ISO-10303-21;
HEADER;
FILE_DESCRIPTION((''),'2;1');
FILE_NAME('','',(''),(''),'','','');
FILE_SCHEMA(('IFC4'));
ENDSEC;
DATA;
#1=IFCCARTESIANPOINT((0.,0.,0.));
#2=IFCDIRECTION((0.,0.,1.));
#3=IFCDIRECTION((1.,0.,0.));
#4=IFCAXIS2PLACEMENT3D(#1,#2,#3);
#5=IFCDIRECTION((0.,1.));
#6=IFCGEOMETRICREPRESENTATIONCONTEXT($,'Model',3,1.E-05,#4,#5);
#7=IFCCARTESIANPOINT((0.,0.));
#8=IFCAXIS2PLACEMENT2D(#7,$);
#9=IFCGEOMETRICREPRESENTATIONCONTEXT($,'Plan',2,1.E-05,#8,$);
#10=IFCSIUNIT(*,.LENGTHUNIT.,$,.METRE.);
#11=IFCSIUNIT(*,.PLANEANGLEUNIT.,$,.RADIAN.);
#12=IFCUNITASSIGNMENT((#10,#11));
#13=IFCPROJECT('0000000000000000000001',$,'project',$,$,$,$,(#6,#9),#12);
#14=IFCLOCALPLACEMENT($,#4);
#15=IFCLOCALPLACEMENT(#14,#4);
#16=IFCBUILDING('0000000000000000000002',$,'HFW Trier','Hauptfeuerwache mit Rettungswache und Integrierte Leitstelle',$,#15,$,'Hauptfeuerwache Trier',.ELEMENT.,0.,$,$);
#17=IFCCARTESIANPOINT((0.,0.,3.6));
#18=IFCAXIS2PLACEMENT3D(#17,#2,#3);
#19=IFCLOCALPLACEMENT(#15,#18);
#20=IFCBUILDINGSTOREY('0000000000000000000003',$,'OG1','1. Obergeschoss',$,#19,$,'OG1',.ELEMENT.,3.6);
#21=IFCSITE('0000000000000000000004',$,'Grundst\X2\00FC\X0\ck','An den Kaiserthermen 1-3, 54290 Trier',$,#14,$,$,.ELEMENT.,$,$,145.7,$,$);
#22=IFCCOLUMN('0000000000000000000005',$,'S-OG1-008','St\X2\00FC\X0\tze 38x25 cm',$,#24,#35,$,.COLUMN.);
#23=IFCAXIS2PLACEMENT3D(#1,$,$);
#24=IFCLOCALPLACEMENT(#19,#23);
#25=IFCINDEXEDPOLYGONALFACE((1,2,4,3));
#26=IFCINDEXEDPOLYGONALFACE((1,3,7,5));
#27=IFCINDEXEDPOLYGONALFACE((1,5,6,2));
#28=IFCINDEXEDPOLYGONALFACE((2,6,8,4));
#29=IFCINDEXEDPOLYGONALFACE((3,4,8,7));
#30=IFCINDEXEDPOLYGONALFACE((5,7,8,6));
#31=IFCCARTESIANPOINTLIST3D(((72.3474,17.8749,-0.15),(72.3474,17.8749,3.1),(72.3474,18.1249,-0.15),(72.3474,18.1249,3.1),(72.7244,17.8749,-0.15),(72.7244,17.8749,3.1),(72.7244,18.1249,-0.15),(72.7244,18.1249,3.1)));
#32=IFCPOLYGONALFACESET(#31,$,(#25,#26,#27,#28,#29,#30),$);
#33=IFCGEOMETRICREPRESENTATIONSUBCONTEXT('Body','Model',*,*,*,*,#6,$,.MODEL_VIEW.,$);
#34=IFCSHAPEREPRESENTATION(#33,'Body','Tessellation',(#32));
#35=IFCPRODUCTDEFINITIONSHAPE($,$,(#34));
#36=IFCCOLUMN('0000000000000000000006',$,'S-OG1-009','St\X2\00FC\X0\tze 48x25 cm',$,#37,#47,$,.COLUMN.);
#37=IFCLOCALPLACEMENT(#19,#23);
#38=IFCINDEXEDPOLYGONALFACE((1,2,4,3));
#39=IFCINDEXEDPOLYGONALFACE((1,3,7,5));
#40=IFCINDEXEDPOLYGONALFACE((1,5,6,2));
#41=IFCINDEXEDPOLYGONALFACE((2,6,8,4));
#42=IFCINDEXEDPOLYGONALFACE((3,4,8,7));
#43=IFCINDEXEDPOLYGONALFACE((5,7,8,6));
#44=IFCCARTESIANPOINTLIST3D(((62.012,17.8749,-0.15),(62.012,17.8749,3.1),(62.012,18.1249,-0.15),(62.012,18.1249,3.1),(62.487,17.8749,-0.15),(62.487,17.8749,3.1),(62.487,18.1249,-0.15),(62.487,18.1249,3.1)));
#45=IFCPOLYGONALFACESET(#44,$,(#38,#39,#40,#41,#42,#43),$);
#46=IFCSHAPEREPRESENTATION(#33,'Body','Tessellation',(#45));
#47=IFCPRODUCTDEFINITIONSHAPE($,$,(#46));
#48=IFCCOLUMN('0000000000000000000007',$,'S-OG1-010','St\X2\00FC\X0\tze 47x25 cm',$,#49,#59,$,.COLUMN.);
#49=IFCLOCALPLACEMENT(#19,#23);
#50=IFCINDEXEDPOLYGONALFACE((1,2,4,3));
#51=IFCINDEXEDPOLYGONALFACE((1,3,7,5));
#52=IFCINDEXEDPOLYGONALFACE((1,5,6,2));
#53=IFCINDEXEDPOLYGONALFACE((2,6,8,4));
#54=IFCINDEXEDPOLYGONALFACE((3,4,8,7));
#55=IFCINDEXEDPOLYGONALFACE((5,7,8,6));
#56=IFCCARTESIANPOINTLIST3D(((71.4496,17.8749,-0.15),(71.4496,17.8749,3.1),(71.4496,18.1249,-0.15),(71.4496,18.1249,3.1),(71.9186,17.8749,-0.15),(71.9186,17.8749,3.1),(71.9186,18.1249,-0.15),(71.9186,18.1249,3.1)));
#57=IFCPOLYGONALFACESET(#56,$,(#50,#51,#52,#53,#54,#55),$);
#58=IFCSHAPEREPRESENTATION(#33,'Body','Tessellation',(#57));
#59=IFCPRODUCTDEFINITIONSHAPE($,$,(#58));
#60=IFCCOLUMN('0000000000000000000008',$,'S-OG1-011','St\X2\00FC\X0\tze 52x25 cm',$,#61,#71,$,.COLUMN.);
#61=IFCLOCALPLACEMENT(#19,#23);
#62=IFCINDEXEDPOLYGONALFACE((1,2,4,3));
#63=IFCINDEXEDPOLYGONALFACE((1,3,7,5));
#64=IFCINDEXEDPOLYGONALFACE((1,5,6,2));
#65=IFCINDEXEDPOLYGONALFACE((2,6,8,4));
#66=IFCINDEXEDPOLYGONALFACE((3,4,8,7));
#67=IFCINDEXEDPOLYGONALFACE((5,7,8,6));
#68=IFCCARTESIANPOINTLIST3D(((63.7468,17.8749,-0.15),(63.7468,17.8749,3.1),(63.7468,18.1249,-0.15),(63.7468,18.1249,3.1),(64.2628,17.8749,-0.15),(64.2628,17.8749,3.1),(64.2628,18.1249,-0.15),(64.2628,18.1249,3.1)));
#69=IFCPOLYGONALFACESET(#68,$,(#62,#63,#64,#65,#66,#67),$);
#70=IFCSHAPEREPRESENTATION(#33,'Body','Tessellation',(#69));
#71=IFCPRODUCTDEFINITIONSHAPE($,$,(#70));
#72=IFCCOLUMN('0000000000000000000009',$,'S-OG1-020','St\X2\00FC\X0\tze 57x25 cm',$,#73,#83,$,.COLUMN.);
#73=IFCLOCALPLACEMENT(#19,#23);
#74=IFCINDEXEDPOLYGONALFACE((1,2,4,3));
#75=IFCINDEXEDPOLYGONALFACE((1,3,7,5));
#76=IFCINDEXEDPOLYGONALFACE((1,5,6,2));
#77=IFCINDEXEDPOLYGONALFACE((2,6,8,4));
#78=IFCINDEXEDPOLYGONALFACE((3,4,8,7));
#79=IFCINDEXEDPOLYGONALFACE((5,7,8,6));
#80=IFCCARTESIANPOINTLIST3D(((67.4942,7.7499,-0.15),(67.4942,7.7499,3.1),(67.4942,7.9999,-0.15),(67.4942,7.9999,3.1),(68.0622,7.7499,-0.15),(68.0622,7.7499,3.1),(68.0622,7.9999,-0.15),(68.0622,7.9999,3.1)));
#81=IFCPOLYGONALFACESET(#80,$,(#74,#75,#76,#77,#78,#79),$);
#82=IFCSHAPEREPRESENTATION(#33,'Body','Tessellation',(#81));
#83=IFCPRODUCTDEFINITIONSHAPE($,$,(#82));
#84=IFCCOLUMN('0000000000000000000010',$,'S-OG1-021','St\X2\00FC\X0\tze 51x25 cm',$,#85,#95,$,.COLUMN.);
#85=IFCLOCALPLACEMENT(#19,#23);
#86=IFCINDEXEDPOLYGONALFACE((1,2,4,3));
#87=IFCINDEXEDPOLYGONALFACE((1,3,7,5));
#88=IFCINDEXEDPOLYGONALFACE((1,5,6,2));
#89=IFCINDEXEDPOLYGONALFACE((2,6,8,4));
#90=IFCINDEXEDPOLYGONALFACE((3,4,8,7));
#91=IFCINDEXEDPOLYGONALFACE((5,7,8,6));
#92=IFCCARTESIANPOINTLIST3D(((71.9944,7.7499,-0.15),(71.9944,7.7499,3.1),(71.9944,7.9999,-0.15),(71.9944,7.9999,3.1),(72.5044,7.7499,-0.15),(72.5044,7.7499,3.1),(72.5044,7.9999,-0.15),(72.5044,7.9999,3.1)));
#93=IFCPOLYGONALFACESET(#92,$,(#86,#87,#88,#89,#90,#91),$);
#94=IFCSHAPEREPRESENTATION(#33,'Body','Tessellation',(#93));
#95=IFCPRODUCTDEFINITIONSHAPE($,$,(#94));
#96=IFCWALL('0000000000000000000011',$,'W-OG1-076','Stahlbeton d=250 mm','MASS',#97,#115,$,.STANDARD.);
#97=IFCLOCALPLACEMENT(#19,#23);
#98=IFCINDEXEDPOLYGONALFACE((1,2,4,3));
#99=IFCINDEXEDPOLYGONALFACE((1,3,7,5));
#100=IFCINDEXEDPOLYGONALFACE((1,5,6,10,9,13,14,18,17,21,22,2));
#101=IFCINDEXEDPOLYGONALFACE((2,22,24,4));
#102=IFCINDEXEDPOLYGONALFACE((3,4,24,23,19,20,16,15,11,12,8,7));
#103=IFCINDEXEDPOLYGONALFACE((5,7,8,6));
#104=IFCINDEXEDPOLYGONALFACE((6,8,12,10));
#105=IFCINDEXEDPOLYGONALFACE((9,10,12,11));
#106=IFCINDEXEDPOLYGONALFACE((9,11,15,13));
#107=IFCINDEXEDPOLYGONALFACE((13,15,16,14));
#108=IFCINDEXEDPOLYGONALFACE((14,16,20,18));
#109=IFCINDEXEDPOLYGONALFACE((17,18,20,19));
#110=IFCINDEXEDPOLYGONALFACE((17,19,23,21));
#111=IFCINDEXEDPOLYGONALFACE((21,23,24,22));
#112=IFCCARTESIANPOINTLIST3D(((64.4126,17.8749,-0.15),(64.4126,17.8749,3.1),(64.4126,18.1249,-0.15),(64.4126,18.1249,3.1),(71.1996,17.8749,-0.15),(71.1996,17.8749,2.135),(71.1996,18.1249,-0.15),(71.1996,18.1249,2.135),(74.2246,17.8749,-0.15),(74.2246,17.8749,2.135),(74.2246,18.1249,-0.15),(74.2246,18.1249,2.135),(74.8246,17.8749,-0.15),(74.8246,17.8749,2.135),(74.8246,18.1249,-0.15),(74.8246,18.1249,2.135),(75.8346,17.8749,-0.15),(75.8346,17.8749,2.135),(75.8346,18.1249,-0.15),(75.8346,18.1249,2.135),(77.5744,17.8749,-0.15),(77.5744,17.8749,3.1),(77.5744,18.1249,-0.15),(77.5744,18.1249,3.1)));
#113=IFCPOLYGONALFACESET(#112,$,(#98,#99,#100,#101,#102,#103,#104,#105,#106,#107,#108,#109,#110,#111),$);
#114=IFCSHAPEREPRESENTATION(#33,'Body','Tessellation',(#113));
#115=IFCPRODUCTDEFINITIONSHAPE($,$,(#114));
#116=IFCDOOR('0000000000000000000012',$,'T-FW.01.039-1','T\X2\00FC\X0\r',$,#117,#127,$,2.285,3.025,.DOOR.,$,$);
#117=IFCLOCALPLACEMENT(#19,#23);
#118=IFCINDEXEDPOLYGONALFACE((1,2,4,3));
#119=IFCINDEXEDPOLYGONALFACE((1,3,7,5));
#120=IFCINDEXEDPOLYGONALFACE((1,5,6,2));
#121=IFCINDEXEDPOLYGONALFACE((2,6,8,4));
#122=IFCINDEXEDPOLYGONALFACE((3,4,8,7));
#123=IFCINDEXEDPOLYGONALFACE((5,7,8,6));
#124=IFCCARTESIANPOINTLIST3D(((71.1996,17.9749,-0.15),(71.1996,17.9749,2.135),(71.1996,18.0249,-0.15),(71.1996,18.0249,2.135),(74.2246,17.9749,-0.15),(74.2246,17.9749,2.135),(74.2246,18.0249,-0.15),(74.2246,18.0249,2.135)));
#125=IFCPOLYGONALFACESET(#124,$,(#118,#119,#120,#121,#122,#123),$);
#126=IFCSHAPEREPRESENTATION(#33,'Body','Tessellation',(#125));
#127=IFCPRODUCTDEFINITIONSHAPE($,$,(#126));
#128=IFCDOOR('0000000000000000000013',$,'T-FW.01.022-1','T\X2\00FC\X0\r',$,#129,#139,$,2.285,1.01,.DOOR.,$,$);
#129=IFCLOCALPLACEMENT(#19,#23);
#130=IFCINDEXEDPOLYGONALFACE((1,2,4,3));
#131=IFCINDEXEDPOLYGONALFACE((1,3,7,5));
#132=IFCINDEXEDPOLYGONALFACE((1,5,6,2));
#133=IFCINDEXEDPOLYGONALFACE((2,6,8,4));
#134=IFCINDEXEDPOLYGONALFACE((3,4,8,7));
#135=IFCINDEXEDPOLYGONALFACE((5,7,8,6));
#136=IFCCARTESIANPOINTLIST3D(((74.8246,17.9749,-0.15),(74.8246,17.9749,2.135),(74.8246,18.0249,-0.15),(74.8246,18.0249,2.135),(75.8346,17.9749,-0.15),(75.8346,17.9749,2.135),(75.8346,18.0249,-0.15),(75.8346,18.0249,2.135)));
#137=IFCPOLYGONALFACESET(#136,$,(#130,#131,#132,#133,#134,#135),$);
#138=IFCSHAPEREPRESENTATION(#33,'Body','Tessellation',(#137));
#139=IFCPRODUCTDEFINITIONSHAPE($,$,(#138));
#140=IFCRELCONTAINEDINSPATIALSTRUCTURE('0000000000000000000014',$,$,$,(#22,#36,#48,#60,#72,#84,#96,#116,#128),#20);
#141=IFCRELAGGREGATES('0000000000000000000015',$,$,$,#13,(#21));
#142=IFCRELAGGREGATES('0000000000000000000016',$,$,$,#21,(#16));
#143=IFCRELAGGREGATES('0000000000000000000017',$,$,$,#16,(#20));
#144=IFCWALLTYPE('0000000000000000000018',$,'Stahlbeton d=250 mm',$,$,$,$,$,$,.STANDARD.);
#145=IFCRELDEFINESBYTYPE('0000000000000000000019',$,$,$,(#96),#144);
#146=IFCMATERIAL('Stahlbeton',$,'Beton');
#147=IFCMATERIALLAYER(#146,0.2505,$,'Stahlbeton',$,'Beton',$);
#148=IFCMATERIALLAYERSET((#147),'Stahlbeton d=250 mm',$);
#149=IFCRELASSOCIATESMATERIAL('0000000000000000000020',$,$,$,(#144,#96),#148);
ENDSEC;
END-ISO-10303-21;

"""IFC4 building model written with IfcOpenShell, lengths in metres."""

from ifc_helpers import new_model, si_unit, direction, frame, frame_2d, origin_with_axes, origin_2d, place, context, subcontext, project, spatial, rectangle, extrude, material, layer, layer_set, layer_usage, type_object, element, fill, save


model = new_model("IFC4")

# Units and contexts
model_context = context("Model", 3, precision=1e-05, world=origin_with_axes(), true_north=direction((0.0, 1.0)))
plan_context = context("Plan", 2, precision=1e-05, world=origin_2d())
body_context = subcontext(model_context, "Body", "Model", "MODEL_VIEW")
ifc_project = project(units=[si_unit("LENGTHUNIT", "METRE"), si_unit("PLANEANGLEUNIT", "RADIAN")], contexts=[model_context, plan_context])

# Site, building, storey
site_placement = place(None, origin_with_axes())
site = spatial("IfcSite", under=ifc_project, at=site_placement, Name="Grundstück", Description="An den Kaiserthermen 1-3, 54290 Trier", CompositionType="ELEMENT", RefElevation=145.7)
building_placement = place(site_placement, origin_with_axes())
building = spatial("IfcBuilding", under=site, at=building_placement, Name="HFW Trier", Description="Hauptfeuerwache mit Rettungswache und Integrierte Leitstelle", LongName="Hauptfeuerwache Trier", CompositionType="ELEMENT", ElevationOfRefHeight=0.0)
storey_placement = place(building_placement, frame((0.0, 0.0, 3.6), z_axis=(0.0, 0.0, 1.0), x_axis=(1.0, 0.0, 0.0)))
storey = spatial("IfcBuildingStorey", under=building, at=storey_placement, Name="OG1", Description="1. Obergeschoss", LongName="OG1", CompositionType="ELEMENT", Elevation=3.6)

# Columns
column_1_placement = place(storey_placement, frame((72.3474, 17.9999, -0.15), z_axis=(0.0, 0.0, 1.0), x_axis=(1.0, 0.0, 0.0)))
element("IfcColumn", 1, at=column_1_placement, inside=storey, Name="S-OG1-008", Description="Stütze 38x25 cm", PredefinedType="COLUMN", context=body_context, shape_type="SweptSolid", body=[
    extrude(rectangle(XDim=0.377, YDim=0.25, at=frame_2d((0.1885, 0.0))), origin_with_axes(), (0.0, 0.0, 1.0), 3.25),
])
column_2_placement = place(storey_placement, frame((62.012, 17.9999, -0.15), z_axis=(0.0, 0.0, 1.0), x_axis=(1.0, 0.0, 0.0)))
element("IfcColumn", 2, at=column_2_placement, inside=storey, Name="S-OG1-009", Description="Stütze 48x25 cm", PredefinedType="COLUMN", context=body_context, shape_type="SweptSolid", body=[
    extrude(rectangle(XDim=0.475, YDim=0.25, at=frame_2d((0.2375, 0.0))), origin_with_axes(), (0.0, 0.0, 1.0), 3.25),
])
column_3_placement = place(storey_placement, frame((71.4496, 17.9999, -0.15), z_axis=(0.0, 0.0, 1.0), x_axis=(1.0, 0.0, 0.0)))
element("IfcColumn", 3, at=column_3_placement, inside=storey, Name="S-OG1-010", Description="Stütze 47x25 cm", PredefinedType="COLUMN", context=body_context, shape_type="SweptSolid", body=[
    extrude(rectangle(XDim=0.469, YDim=0.25, at=frame_2d((0.2345, 0.0))), origin_with_axes(), (0.0, 0.0, 1.0), 3.25),
])
column_4_placement = place(storey_placement, frame((63.7468, 17.9999, -0.15), z_axis=(0.0, 0.0, 1.0), x_axis=(1.0, 0.0, 0.0)))
element("IfcColumn", 4, at=column_4_placement, inside=storey, Name="S-OG1-011", Description="Stütze 52x25 cm", PredefinedType="COLUMN", context=body_context, shape_type="SweptSolid", body=[
    extrude(rectangle(XDim=0.516, YDim=0.25, at=frame_2d((0.258, 0.0))), origin_with_axes(), (0.0, 0.0, 1.0), 3.25),
])
column_5_placement = place(storey_placement, frame((67.4942, 7.8749, -0.15), z_axis=(0.0, 0.0, 1.0), x_axis=(1.0, 0.0, 0.0)))
element("IfcColumn", 5, at=column_5_placement, inside=storey, Name="S-OG1-020", Description="Stütze 57x25 cm", PredefinedType="COLUMN", context=body_context, shape_type="SweptSolid", body=[
    extrude(rectangle(XDim=0.568, YDim=0.25, at=frame_2d((0.284, 0.0))), origin_with_axes(), (0.0, 0.0, 1.0), 3.25),
])
column_6_placement = place(storey_placement, frame((71.9944, 7.8749, -0.15), z_axis=(0.0, 0.0, 1.0), x_axis=(1.0, 0.0, 0.0)))
element("IfcColumn", 6, at=column_6_placement, inside=storey, Name="S-OG1-021", Description="Stütze 51x25 cm", PredefinedType="COLUMN", context=body_context, shape_type="SweptSolid", body=[
    extrude(rectangle(XDim=0.51, YDim=0.25, at=frame_2d((0.255, 0.0))), origin_with_axes(), (0.0, 0.0, 1.0), 3.25),
])

# Wall, openings, doors
ifc_material_1 = material(Name="Stahlbeton", Category="Beton")
ifc_layer_1 = layer(ifc_material_1, 0.2505, Name="Stahlbeton", Category="Beton")
ifc_layer_set_1 = layer_set([ifc_layer_1], Name="Stahlbeton d=250 mm")
ifc_layer_usage_1 = layer_usage(ifc_layer_set_1, "AXIS2", "POSITIVE", -0.125)
wall_type_1 = type_object("IfcWallType", Name="Stahlbeton d=250 mm", PredefinedType="STANDARD", material=ifc_layer_set_1)
wall_1_placement = place(storey_placement, frame((64.4126, 17.9999, -0.15), z_axis=(0.0, 0.0, 1.0), x_axis=(1.0, 0.0, 0.0)))
wall_1 = element("IfcWall", 7, at=wall_1_placement, inside=storey, type_object=wall_type_1, material=ifc_layer_usage_1, Name="W-OG1-076", Description="Stahlbeton d=250 mm", ObjectType="MASS", PredefinedType="STANDARD", context=body_context, shape_type="SweptSolid", body=[
    extrude(rectangle(XDim=13.1618, YDim=0.25, at=frame_2d((6.5809, 0.0))), origin_with_axes(), (0.0, 0.0, 1.0), 3.25),
])
opening_1_placement = place(wall_1_placement, frame((6.787, 0.0, 0.0), z_axis=(0.0, 0.0, 1.0), x_axis=(1.0, 0.0, 0.0)))
opening_1 = element("IfcOpeningElement", 8, at=opening_1_placement, cuts=wall_1, PredefinedType="OPENING", context=body_context, shape_type="SweptSolid", body=[
    extrude(rectangle(XDim=3.025, YDim=0.35, at=frame_2d((1.5125, 0.0))), origin_with_axes(), (0.0, 0.0, 1.0), 2.285),
])
opening_2_placement = place(wall_1_placement, frame((10.412, 0.0, 0.0), z_axis=(0.0, 0.0, 1.0), x_axis=(1.0, 0.0, 0.0)))
opening_2 = element("IfcOpeningElement", 9, at=opening_2_placement, cuts=wall_1, PredefinedType="OPENING", context=body_context, shape_type="SweptSolid", body=[
    extrude(rectangle(XDim=1.01, YDim=0.35, at=frame_2d((0.505, 0.0))), origin_with_axes(), (0.0, 0.0, 1.0), 2.285),
])
door_1_placement = place(wall_1_placement, frame((6.787, 0.0, 0.0), z_axis=(0.0, 0.0, 1.0), x_axis=(1.0, 0.0, 0.0)))
door_1 = element("IfcDoor", 10, at=door_1_placement, inside=storey, Name="T-FW.01.039-1", Description="Tür", OverallHeight=2.285, OverallWidth=3.025, PredefinedType="DOOR", context=body_context, shape_type="SweptSolid", body=[
    extrude(rectangle(XDim=3.025, YDim=0.05, at=frame_2d((1.5125, 0.0))), origin_with_axes(), (0.0, 0.0, 1.0), 2.285),
])
fill(opening_1, door_1)
door_2_placement = place(wall_1_placement, frame((10.412, 0.0, 0.0), z_axis=(0.0, 0.0, 1.0), x_axis=(1.0, 0.0, 0.0)))
door_2 = element("IfcDoor", 11, at=door_2_placement, inside=storey, Name="T-FW.01.022-1", Description="Tür", OverallHeight=2.285, OverallWidth=1.01, PredefinedType="DOOR", context=body_context, shape_type="SweptSolid", body=[
    extrude(rectangle(XDim=1.01, YDim=0.05, at=frame_2d((0.505, 0.0))), origin_with_axes(), (0.0, 0.0, 1.0), 2.285),
])
fill(opening_2, door_2)

save(model, "model.ifc")
